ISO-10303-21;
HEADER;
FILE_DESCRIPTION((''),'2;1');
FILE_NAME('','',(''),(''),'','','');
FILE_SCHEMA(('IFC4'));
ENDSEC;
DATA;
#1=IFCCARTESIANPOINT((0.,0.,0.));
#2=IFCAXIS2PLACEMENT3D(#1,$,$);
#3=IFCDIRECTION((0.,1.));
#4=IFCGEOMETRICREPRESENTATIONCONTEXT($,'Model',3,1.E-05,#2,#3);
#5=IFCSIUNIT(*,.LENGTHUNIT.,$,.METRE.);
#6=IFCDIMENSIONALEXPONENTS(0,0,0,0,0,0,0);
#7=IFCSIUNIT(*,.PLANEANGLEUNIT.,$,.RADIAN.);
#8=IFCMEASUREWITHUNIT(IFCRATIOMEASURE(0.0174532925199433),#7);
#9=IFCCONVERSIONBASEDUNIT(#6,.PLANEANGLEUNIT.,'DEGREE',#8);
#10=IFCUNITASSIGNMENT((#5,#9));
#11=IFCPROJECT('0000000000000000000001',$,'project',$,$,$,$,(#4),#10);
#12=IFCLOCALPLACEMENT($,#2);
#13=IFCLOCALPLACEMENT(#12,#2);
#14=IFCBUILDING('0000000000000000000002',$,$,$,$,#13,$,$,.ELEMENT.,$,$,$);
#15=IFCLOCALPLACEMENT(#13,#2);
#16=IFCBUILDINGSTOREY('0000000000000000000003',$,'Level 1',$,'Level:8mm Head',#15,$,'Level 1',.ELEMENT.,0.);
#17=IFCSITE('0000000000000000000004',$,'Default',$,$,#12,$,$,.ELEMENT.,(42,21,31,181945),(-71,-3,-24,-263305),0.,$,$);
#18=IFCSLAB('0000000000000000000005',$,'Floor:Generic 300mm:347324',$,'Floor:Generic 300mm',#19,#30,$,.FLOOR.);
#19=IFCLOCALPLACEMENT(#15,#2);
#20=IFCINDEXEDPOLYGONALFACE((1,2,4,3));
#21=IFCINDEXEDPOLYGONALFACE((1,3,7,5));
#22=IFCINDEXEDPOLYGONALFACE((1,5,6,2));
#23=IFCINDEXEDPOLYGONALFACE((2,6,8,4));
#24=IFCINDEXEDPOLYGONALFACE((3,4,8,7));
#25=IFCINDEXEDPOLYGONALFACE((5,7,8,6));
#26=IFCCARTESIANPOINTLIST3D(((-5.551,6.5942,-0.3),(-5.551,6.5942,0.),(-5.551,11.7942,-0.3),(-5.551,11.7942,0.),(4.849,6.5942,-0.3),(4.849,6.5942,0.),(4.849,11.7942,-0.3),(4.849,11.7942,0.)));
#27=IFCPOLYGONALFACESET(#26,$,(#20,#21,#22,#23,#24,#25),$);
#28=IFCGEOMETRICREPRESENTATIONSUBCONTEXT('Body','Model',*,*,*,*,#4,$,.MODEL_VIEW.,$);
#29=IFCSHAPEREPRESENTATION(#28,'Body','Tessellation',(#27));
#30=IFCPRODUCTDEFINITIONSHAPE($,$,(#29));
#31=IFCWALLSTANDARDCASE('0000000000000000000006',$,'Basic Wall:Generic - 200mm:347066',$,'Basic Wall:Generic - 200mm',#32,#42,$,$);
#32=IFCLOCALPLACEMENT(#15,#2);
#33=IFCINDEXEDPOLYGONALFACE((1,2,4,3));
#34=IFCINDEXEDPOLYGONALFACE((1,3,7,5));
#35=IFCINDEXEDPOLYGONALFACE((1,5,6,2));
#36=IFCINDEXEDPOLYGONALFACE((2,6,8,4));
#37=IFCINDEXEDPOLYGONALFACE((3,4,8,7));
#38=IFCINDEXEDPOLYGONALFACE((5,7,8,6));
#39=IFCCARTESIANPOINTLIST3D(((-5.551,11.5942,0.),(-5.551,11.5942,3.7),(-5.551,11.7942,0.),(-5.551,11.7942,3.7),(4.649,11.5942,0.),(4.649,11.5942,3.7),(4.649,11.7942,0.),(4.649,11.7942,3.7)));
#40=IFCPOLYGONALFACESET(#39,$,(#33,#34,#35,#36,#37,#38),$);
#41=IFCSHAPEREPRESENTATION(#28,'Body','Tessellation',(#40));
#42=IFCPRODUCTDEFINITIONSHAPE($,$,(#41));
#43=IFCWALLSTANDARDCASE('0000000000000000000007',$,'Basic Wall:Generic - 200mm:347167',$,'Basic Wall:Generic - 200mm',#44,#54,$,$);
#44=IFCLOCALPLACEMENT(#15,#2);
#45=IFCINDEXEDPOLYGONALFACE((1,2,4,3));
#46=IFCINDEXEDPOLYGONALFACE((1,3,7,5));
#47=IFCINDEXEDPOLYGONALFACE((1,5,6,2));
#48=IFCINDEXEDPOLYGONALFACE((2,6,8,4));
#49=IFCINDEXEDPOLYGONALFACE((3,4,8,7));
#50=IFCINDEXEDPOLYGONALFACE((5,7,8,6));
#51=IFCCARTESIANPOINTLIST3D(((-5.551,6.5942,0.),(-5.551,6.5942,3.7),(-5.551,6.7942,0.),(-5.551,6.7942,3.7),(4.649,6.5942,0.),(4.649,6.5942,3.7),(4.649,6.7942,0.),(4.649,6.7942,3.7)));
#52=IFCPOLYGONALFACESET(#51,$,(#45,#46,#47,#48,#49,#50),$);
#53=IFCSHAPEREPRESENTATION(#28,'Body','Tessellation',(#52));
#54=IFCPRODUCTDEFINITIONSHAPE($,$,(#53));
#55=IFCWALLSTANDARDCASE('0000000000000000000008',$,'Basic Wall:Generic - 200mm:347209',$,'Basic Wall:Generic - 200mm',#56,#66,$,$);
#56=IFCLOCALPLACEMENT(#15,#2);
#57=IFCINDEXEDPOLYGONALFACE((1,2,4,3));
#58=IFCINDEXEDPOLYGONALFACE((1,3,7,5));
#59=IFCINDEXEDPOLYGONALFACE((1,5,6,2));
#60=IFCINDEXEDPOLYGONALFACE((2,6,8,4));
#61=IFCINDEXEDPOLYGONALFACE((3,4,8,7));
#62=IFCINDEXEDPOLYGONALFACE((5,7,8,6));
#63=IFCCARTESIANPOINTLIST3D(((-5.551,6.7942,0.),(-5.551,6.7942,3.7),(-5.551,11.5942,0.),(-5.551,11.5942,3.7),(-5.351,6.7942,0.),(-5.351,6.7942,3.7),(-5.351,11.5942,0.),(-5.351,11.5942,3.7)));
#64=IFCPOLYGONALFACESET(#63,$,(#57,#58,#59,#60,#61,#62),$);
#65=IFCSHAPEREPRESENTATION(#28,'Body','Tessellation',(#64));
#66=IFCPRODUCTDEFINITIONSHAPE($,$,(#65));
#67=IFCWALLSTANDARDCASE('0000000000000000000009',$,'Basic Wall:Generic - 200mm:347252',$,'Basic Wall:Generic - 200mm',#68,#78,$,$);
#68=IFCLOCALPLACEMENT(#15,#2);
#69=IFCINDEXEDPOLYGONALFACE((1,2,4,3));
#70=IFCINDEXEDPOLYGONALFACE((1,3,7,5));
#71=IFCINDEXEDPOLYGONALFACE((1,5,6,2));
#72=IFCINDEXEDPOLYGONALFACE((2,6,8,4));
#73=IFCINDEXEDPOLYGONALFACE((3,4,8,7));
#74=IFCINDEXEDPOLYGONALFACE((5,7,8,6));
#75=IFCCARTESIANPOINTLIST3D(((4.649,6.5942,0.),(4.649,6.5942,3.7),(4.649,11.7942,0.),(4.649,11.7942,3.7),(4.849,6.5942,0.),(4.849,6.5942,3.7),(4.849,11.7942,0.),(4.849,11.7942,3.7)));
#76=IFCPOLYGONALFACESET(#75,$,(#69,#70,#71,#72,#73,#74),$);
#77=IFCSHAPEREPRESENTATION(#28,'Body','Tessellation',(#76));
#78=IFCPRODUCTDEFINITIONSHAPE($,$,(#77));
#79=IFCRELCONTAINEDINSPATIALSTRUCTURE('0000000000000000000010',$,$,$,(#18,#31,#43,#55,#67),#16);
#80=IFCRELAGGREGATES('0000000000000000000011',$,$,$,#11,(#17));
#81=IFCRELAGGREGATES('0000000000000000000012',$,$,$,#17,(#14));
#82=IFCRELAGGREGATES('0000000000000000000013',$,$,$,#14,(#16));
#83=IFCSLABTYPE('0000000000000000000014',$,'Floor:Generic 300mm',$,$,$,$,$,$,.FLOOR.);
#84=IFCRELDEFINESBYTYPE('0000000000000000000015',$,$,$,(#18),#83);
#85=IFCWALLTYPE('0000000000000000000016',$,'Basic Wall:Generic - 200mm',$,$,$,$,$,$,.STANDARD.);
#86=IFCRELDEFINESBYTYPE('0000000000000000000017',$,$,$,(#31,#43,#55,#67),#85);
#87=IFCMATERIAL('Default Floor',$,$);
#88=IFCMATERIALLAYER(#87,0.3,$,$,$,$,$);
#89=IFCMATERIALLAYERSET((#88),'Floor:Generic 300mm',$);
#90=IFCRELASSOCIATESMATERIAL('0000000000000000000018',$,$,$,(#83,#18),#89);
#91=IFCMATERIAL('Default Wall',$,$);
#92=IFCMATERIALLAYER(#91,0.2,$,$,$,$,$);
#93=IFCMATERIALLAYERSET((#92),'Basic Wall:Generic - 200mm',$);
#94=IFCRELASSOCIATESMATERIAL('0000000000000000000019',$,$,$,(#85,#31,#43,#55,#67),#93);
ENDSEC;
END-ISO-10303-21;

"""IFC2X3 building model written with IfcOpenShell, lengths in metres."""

from ifc_helpers import new_model, entity, si_unit, converted_unit, direction, frame, frame_2d, origin, origin_2d_with_axis, place, context, subcontext, project, spatial, rectangle, extrude, material, layer, layer_set, layer_usage, type_object, element, save


model = new_model("IFC2X3")

# Units and contexts
model_context = context("Model", 3, precision=1e-05, world=origin(), true_north=direction((0.0, 1.0)))
body_context = subcontext(model_context, "Body", "Model", "MODEL_VIEW")
ifc_project = project(units=[si_unit("LENGTHUNIT", "METRE"), converted_unit("PLANEANGLEUNIT", "DEGREE", entity("IfcRatioMeasure", 0.0174532925199433), si_unit("PLANEANGLEUNIT", "RADIAN"), dimensions=[0, 0, 0, 0, 0, 0, 0])], contexts=[model_context])

# Site, building, storey
site_placement = place(None, origin())
site = spatial("IfcSite", under=ifc_project, at=site_placement, Name="Default", CompositionType="ELEMENT", RefLatitude=(42, 21, 31, 181945), RefLongitude=(-71, -3, -24, -263305), RefElevation=0.0)
building_placement = place(site_placement, origin())
building = spatial("IfcBuilding", under=site, at=building_placement, CompositionType="ELEMENT")
storey_placement = place(building_placement, origin())
storey = spatial("IfcBuildingStorey", under=building, at=storey_placement, Name="Level 1", ObjectType="Level:8mm Head", LongName="Level 1", CompositionType="ELEMENT", Elevation=0.0)

# Slab
ifc_material_1 = material(Name="Default Floor")
ifc_layer_1 = layer(ifc_material_1, 0.3)
ifc_layer_set_1 = layer_set([ifc_layer_1], Name="Floor:Generic 300mm")
ifc_layer_usage_1 = layer_usage(ifc_layer_set_1, "AXIS3", "POSITIVE", 0.0)
slab_type = type_object("IfcSlabType", Name="Floor:Generic 300mm", PredefinedType="FLOOR", material=ifc_layer_set_1)
slab_placement = place(storey_placement, origin())
element("IfcSlab", 1, at=slab_placement, inside=storey, type_object=slab_type, material=ifc_layer_usage_1, Name="Floor:Generic 300mm:347324", ObjectType="Floor:Generic 300mm", PredefinedType="FLOOR", context=body_context, shape_type="SweptSolid", body=[
    extrude(rectangle(XDim=5.2, YDim=10.4, at=origin_2d_with_axis()), frame((-0.351, 9.1942, 0.0), z_axis=(0.0, 0.0, -1.0), x_axis=(0.0, 1.0, 0.0)), (0.0, 0.0, 1.0), 0.3),
])

# Walls
ifc_material_2 = material(Name="Default Wall")
ifc_layer_2 = layer(ifc_material_2, 0.2)
ifc_layer_set_2 = layer_set([ifc_layer_2], Name="Basic Wall:Generic - 200mm")
ifc_layer_usage_2 = layer_usage(ifc_layer_set_2, "AXIS2", "NEGATIVE", 0.1)
wall_type = type_object("IfcWallType", Name="Basic Wall:Generic - 200mm", PredefinedType="STANDARD", material=ifc_layer_set_2)
wall_1_placement = place(storey_placement, frame((-5.551, 11.6942, 0.0)))
element("IfcWallStandardCase", 2, at=wall_1_placement, inside=storey, type_object=wall_type, material=ifc_layer_usage_2, Name="Basic Wall:Generic - 200mm:347066", ObjectType="Basic Wall:Generic - 200mm", context=body_context, shape_type="SweptSolid", body=[
    extrude(rectangle(XDim=10.2, YDim=0.2, at=frame_2d((5.1, 0.0), x_axis=(-1.0, 0.0))), origin(), (0.0, 0.0, 1.0), 3.7),
])
ifc_layer_usage_3 = layer_usage(ifc_layer_set_2, "AXIS2", "NEGATIVE", 0.1)
wall_2_placement = place(storey_placement, frame((4.649, 6.6942, 0.0), z_axis=(0.0, 0.0, 1.0), x_axis=(-1.0, 0.0, 0.0)))
element("IfcWallStandardCase", 3, at=wall_2_placement, inside=storey, type_object=wall_type, material=ifc_layer_usage_3, Name="Basic Wall:Generic - 200mm:347167", ObjectType="Basic Wall:Generic - 200mm", context=body_context, shape_type="SweptSolid", body=[
    extrude(rectangle(XDim=10.2, YDim=0.2, at=frame_2d((5.1, 0.0), x_axis=(-1.0, 0.0))), origin(), (0.0, 0.0, 1.0), 3.7),
])
ifc_layer_usage_4 = layer_usage(ifc_layer_set_2, "AXIS2", "NEGATIVE", 0.1)
wall_3_placement = place(storey_placement, frame((-5.451, 6.7942, 0.0), z_axis=(0.0, 0.0, 1.0), x_axis=(0.0, 1.0, 0.0)))
element("IfcWallStandardCase", 4, at=wall_3_placement, inside=storey, type_object=wall_type, material=ifc_layer_usage_4, Name="Basic Wall:Generic - 200mm:347209", ObjectType="Basic Wall:Generic - 200mm", context=body_context, shape_type="SweptSolid", body=[
    extrude(rectangle(XDim=4.8, YDim=0.2, at=frame_2d((2.4, 0.0), x_axis=(-1.0, 0.0))), origin(), (0.0, 0.0, 1.0), 3.7),
])
ifc_layer_usage_5 = layer_usage(ifc_layer_set_2, "AXIS2", "NEGATIVE", 0.1)
wall_4_placement = place(storey_placement, frame((4.749, 11.7942, 0.0), z_axis=(0.0, 0.0, 1.0), x_axis=(0.0, -1.0, 0.0)))
element("IfcWallStandardCase", 5, at=wall_4_placement, inside=storey, type_object=wall_type, material=ifc_layer_usage_5, Name="Basic Wall:Generic - 200mm:347252", ObjectType="Basic Wall:Generic - 200mm", context=body_context, shape_type="SweptSolid", body=[
    extrude(rectangle(XDim=5.2, YDim=0.2, at=frame_2d((2.6, 0.0), x_axis=(-1.0, 0.0))), origin(), (0.0, 0.0, 1.0), 3.7),
])

save(model, "model.ifc")
